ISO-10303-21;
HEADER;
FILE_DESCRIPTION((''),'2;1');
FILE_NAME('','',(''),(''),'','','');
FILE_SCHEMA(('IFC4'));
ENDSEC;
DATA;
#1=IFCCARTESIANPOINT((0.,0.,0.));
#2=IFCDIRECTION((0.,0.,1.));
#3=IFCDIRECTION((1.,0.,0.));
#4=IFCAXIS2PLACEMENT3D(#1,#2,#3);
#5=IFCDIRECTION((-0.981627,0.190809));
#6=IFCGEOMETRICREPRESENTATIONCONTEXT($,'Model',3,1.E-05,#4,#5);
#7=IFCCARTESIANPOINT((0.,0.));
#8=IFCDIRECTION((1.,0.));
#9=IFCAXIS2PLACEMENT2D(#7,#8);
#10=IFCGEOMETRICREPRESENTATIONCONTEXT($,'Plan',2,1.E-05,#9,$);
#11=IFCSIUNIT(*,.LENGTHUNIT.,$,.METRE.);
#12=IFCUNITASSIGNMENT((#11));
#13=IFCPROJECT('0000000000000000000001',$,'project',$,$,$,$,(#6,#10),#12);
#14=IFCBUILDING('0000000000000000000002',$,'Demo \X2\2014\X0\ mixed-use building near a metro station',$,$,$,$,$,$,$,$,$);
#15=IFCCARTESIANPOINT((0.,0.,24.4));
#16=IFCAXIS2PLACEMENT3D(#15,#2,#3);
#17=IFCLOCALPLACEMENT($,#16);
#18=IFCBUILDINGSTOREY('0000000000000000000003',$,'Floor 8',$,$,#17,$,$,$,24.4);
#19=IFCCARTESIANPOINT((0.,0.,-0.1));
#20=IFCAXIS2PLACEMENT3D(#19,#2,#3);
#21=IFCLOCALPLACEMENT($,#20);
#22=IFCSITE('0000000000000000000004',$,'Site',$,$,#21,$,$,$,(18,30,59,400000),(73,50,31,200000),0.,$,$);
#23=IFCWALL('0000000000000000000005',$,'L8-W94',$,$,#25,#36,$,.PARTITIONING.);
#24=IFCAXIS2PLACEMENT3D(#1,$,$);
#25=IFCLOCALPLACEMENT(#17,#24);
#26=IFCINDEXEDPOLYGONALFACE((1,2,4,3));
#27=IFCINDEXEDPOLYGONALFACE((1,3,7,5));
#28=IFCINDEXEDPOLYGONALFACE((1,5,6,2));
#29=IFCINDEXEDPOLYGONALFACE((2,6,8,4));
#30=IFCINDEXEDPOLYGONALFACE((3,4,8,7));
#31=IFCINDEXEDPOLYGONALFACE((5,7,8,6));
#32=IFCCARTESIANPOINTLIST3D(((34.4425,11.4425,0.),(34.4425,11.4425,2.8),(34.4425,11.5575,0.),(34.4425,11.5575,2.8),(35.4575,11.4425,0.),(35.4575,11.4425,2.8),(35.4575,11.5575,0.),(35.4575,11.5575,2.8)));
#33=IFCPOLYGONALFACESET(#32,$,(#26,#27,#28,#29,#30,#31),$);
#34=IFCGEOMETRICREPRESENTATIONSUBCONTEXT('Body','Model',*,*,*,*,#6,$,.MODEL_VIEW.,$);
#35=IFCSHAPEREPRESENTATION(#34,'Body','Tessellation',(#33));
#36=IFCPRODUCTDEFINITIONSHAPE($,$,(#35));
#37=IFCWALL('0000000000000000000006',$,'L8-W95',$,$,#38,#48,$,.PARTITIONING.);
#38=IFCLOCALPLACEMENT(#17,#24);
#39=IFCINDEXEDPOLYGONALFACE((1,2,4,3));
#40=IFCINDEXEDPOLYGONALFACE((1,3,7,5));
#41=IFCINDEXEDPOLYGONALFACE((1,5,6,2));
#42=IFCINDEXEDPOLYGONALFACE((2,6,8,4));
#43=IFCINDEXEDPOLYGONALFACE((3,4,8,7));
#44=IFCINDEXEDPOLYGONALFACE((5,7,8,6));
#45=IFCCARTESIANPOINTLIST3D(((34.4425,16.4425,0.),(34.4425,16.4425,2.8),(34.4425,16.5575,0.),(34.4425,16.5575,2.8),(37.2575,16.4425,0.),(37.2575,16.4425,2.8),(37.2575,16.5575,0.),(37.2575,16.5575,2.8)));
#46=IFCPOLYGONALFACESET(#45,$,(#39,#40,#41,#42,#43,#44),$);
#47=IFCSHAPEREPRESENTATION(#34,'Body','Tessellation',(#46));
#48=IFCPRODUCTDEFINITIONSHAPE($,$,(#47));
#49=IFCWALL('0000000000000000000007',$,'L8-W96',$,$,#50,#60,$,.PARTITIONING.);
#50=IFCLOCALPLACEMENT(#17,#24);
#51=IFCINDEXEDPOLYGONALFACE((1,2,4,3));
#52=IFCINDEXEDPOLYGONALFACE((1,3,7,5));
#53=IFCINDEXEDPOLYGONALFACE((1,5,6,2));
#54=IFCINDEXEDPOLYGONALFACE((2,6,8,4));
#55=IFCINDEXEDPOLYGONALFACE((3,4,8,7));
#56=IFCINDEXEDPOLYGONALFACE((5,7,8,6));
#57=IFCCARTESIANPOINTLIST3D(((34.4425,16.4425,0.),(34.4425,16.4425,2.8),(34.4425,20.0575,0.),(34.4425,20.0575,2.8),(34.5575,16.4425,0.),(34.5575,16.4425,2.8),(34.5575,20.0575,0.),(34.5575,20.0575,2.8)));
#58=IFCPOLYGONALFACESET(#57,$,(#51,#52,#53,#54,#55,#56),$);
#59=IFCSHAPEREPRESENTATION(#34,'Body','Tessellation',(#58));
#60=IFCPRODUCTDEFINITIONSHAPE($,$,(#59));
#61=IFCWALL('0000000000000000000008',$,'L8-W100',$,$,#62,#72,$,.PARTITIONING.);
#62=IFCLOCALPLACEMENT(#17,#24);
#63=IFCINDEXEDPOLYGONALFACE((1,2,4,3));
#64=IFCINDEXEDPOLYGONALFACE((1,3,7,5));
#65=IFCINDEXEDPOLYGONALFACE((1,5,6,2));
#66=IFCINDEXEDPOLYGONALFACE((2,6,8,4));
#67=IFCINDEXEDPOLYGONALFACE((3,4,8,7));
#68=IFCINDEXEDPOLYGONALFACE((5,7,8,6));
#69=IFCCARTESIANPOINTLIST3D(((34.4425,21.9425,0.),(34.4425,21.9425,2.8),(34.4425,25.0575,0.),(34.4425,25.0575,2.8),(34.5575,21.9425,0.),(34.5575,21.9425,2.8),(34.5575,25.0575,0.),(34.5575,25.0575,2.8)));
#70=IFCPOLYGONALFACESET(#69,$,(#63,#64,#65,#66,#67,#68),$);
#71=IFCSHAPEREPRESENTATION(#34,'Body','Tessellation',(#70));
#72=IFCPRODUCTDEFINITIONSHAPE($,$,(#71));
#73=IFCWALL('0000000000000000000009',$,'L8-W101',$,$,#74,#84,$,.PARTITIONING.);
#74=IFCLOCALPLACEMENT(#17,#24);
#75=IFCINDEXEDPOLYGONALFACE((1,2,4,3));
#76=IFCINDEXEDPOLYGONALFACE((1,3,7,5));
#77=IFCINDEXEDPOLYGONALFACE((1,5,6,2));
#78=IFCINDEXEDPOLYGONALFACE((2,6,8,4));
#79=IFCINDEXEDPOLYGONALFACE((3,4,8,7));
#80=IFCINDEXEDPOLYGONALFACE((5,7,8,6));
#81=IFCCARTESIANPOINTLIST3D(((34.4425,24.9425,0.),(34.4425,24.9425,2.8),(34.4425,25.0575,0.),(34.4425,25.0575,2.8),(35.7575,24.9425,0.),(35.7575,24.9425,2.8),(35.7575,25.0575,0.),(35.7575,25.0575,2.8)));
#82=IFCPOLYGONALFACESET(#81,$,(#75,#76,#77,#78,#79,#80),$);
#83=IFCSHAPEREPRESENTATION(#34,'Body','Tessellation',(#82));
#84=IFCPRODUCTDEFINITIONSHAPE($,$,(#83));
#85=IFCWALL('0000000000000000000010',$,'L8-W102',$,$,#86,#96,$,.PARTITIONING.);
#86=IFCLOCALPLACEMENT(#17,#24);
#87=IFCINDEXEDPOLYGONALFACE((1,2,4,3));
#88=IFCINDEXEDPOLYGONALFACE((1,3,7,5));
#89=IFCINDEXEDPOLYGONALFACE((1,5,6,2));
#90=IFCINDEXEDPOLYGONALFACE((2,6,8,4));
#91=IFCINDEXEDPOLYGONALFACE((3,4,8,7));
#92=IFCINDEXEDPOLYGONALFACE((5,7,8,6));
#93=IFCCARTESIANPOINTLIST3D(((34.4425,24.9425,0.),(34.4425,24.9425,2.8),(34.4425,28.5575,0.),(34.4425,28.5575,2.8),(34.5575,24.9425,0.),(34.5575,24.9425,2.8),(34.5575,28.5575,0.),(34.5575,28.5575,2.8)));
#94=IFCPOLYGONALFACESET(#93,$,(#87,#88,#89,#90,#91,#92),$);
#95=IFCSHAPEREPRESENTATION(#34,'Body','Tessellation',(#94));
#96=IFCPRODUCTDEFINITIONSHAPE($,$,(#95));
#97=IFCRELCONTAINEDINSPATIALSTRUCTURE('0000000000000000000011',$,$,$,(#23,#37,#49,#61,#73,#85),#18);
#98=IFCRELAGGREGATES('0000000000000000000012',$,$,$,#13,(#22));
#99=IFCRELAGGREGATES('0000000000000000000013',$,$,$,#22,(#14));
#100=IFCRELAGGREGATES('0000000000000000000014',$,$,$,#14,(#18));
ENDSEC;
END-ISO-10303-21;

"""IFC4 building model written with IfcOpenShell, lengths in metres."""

from ifc_helpers import new_model, si_unit, direction, frame, origin_with_axes, origin_2d_with_axis, place, context, subcontext, project, spatial, line, indexed_curve, outline, extrude, element, save


model = new_model("IFC4")

# Units and contexts
model_context = context("Model", 3, precision=1e-05, world=origin_with_axes(), true_north=direction((-0.981627, 0.190809)))
plan_context = context("Plan", 2, precision=1e-05, world=origin_2d_with_axis())
body_context = subcontext(model_context, "Body", "Model", "MODEL_VIEW")
ifc_project = project(units=[si_unit("LENGTHUNIT", "METRE")], contexts=[model_context, plan_context])

# Site, building, storey
site_placement = place(None, frame((0.0, 0.0, -0.1), z_axis=(0.0, 0.0, 1.0), x_axis=(1.0, 0.0, 0.0)))
site = spatial("IfcSite", under=ifc_project, at=site_placement, Name="Site", RefLatitude=(18, 30, 59, 400000), RefLongitude=(73, 50, 31, 200000), RefElevation=0.0)
building = spatial("IfcBuilding", under=site, Name="Demo — mixed-use building near a metro station")
storey_placement = place(None, frame((0.0, 0.0, 24.4), z_axis=(0.0, 0.0, 1.0), x_axis=(1.0, 0.0, 0.0)))
storey = spatial("IfcBuildingStorey", under=building, at=storey_placement, Name="Floor 8", Elevation=24.4)

# Walls
wall_1_placement = place(storey_placement, frame((0.0, 0.0, -24.4), z_axis=(0.0, 0.0, 1.0), x_axis=(1.0, 0.0, 0.0)))
element("IfcWall", 1, at=wall_1_placement, inside=storey, Name="L8-W94", PredefinedType="PARTITIONING", context=body_context, shape_type="SweptSolid", body=[
    extrude(outline(indexed_curve([(34.4425, 11.5575), (35.4575, 11.5575), (35.4575, 11.4425), (34.4425, 11.4425)], segments=[line(1, 2, 3, 4, 1)])), frame((0.0, 0.0, 24.4), z_axis=(0.0, 0.0, 1.0), x_axis=(1.0, 0.0, 0.0)), (0.0, 0.0, 1.0), 2.8),
])
wall_2_placement = place(storey_placement, frame((0.0, 0.0, -24.4), z_axis=(0.0, 0.0, 1.0), x_axis=(1.0, 0.0, 0.0)))
element("IfcWall", 2, at=wall_2_placement, inside=storey, Name="L8-W95", PredefinedType="PARTITIONING", context=body_context, shape_type="SweptSolid", body=[
    extrude(outline(indexed_curve([(37.2575, 16.4425), (34.4425, 16.4425), (34.4425, 16.5575), (37.2575, 16.5575)], segments=[line(1, 2, 3, 4, 1)])), frame((0.0, 0.0, 24.4), z_axis=(0.0, 0.0, 1.0), x_axis=(1.0, 0.0, 0.0)), (0.0, 0.0, 1.0), 2.8),
])
wall_3_placement = place(storey_placement, frame((0.0, 0.0, -24.4), z_axis=(0.0, 0.0, 1.0), x_axis=(1.0, 0.0, 0.0)))
element("IfcWall", 3, at=wall_3_placement, inside=storey, Name="L8-W96", PredefinedType="PARTITIONING", context=body_context, shape_type="SweptSolid", body=[
    extrude(outline(indexed_curve([(34.4425, 16.4425), (34.4425, 20.0575), (34.5575, 20.0575), (34.5575, 16.4425)], segments=[line(1, 2, 3, 4, 1)])), frame((0.0, 0.0, 24.4), z_axis=(0.0, 0.0, 1.0), x_axis=(1.0, 0.0, 0.0)), (0.0, 0.0, 1.0), 2.8),
])

# Walls
wall_4_placement = place(storey_placement, frame((0.0, 0.0, -24.4), z_axis=(0.0, 0.0, 1.0), x_axis=(1.0, 0.0, 0.0)))
element("IfcWall", 4, at=wall_4_placement, inside=storey, Name="L8-W100", PredefinedType="PARTITIONING", context=body_context, shape_type="SweptSolid", body=[
    extrude(outline(indexed_curve([(34.4425, 21.9425), (34.4425, 25.0575), (34.5575, 25.0575), (34.5575, 21.9425)], segments=[line(1, 2, 3, 4, 1)])), frame((0.0, 0.0, 24.4), z_axis=(0.0, 0.0, 1.0), x_axis=(1.0, 0.0, 0.0)), (0.0, 0.0, 1.0), 2.8),
])
wall_5_placement = place(storey_placement, frame((0.0, 0.0, -24.4), z_axis=(0.0, 0.0, 1.0), x_axis=(1.0, 0.0, 0.0)))
element("IfcWall", 5, at=wall_5_placement, inside=storey, Name="L8-W101", PredefinedType="PARTITIONING", context=body_context, shape_type="SweptSolid", body=[
    extrude(outline(indexed_curve([(35.7575, 24.9425), (34.4425, 24.9425), (34.4425, 25.0575), (35.7575, 25.0575)], segments=[line(1, 2, 3, 4, 1)])), frame((0.0, 0.0, 24.4), z_axis=(0.0, 0.0, 1.0), x_axis=(1.0, 0.0, 0.0)), (0.0, 0.0, 1.0), 2.8),
])
wall_6_placement = place(storey_placement, frame((0.0, 0.0, -24.4), z_axis=(0.0, 0.0, 1.0), x_axis=(1.0, 0.0, 0.0)))
element("IfcWall", 6, at=wall_6_placement, inside=storey, Name="L8-W102", PredefinedType="PARTITIONING", context=body_context, shape_type="SweptSolid", body=[
    extrude(outline(indexed_curve([(34.4425, 24.9425), (34.4425, 28.5575), (34.5575, 28.5575), (34.5575, 24.9425)], segments=[line(1, 2, 3, 4, 1)])), frame((0.0, 0.0, 24.4), z_axis=(0.0, 0.0, 1.0), x_axis=(1.0, 0.0, 0.0)), (0.0, 0.0, 1.0), 2.8),
])

save(model, "model.ifc")
